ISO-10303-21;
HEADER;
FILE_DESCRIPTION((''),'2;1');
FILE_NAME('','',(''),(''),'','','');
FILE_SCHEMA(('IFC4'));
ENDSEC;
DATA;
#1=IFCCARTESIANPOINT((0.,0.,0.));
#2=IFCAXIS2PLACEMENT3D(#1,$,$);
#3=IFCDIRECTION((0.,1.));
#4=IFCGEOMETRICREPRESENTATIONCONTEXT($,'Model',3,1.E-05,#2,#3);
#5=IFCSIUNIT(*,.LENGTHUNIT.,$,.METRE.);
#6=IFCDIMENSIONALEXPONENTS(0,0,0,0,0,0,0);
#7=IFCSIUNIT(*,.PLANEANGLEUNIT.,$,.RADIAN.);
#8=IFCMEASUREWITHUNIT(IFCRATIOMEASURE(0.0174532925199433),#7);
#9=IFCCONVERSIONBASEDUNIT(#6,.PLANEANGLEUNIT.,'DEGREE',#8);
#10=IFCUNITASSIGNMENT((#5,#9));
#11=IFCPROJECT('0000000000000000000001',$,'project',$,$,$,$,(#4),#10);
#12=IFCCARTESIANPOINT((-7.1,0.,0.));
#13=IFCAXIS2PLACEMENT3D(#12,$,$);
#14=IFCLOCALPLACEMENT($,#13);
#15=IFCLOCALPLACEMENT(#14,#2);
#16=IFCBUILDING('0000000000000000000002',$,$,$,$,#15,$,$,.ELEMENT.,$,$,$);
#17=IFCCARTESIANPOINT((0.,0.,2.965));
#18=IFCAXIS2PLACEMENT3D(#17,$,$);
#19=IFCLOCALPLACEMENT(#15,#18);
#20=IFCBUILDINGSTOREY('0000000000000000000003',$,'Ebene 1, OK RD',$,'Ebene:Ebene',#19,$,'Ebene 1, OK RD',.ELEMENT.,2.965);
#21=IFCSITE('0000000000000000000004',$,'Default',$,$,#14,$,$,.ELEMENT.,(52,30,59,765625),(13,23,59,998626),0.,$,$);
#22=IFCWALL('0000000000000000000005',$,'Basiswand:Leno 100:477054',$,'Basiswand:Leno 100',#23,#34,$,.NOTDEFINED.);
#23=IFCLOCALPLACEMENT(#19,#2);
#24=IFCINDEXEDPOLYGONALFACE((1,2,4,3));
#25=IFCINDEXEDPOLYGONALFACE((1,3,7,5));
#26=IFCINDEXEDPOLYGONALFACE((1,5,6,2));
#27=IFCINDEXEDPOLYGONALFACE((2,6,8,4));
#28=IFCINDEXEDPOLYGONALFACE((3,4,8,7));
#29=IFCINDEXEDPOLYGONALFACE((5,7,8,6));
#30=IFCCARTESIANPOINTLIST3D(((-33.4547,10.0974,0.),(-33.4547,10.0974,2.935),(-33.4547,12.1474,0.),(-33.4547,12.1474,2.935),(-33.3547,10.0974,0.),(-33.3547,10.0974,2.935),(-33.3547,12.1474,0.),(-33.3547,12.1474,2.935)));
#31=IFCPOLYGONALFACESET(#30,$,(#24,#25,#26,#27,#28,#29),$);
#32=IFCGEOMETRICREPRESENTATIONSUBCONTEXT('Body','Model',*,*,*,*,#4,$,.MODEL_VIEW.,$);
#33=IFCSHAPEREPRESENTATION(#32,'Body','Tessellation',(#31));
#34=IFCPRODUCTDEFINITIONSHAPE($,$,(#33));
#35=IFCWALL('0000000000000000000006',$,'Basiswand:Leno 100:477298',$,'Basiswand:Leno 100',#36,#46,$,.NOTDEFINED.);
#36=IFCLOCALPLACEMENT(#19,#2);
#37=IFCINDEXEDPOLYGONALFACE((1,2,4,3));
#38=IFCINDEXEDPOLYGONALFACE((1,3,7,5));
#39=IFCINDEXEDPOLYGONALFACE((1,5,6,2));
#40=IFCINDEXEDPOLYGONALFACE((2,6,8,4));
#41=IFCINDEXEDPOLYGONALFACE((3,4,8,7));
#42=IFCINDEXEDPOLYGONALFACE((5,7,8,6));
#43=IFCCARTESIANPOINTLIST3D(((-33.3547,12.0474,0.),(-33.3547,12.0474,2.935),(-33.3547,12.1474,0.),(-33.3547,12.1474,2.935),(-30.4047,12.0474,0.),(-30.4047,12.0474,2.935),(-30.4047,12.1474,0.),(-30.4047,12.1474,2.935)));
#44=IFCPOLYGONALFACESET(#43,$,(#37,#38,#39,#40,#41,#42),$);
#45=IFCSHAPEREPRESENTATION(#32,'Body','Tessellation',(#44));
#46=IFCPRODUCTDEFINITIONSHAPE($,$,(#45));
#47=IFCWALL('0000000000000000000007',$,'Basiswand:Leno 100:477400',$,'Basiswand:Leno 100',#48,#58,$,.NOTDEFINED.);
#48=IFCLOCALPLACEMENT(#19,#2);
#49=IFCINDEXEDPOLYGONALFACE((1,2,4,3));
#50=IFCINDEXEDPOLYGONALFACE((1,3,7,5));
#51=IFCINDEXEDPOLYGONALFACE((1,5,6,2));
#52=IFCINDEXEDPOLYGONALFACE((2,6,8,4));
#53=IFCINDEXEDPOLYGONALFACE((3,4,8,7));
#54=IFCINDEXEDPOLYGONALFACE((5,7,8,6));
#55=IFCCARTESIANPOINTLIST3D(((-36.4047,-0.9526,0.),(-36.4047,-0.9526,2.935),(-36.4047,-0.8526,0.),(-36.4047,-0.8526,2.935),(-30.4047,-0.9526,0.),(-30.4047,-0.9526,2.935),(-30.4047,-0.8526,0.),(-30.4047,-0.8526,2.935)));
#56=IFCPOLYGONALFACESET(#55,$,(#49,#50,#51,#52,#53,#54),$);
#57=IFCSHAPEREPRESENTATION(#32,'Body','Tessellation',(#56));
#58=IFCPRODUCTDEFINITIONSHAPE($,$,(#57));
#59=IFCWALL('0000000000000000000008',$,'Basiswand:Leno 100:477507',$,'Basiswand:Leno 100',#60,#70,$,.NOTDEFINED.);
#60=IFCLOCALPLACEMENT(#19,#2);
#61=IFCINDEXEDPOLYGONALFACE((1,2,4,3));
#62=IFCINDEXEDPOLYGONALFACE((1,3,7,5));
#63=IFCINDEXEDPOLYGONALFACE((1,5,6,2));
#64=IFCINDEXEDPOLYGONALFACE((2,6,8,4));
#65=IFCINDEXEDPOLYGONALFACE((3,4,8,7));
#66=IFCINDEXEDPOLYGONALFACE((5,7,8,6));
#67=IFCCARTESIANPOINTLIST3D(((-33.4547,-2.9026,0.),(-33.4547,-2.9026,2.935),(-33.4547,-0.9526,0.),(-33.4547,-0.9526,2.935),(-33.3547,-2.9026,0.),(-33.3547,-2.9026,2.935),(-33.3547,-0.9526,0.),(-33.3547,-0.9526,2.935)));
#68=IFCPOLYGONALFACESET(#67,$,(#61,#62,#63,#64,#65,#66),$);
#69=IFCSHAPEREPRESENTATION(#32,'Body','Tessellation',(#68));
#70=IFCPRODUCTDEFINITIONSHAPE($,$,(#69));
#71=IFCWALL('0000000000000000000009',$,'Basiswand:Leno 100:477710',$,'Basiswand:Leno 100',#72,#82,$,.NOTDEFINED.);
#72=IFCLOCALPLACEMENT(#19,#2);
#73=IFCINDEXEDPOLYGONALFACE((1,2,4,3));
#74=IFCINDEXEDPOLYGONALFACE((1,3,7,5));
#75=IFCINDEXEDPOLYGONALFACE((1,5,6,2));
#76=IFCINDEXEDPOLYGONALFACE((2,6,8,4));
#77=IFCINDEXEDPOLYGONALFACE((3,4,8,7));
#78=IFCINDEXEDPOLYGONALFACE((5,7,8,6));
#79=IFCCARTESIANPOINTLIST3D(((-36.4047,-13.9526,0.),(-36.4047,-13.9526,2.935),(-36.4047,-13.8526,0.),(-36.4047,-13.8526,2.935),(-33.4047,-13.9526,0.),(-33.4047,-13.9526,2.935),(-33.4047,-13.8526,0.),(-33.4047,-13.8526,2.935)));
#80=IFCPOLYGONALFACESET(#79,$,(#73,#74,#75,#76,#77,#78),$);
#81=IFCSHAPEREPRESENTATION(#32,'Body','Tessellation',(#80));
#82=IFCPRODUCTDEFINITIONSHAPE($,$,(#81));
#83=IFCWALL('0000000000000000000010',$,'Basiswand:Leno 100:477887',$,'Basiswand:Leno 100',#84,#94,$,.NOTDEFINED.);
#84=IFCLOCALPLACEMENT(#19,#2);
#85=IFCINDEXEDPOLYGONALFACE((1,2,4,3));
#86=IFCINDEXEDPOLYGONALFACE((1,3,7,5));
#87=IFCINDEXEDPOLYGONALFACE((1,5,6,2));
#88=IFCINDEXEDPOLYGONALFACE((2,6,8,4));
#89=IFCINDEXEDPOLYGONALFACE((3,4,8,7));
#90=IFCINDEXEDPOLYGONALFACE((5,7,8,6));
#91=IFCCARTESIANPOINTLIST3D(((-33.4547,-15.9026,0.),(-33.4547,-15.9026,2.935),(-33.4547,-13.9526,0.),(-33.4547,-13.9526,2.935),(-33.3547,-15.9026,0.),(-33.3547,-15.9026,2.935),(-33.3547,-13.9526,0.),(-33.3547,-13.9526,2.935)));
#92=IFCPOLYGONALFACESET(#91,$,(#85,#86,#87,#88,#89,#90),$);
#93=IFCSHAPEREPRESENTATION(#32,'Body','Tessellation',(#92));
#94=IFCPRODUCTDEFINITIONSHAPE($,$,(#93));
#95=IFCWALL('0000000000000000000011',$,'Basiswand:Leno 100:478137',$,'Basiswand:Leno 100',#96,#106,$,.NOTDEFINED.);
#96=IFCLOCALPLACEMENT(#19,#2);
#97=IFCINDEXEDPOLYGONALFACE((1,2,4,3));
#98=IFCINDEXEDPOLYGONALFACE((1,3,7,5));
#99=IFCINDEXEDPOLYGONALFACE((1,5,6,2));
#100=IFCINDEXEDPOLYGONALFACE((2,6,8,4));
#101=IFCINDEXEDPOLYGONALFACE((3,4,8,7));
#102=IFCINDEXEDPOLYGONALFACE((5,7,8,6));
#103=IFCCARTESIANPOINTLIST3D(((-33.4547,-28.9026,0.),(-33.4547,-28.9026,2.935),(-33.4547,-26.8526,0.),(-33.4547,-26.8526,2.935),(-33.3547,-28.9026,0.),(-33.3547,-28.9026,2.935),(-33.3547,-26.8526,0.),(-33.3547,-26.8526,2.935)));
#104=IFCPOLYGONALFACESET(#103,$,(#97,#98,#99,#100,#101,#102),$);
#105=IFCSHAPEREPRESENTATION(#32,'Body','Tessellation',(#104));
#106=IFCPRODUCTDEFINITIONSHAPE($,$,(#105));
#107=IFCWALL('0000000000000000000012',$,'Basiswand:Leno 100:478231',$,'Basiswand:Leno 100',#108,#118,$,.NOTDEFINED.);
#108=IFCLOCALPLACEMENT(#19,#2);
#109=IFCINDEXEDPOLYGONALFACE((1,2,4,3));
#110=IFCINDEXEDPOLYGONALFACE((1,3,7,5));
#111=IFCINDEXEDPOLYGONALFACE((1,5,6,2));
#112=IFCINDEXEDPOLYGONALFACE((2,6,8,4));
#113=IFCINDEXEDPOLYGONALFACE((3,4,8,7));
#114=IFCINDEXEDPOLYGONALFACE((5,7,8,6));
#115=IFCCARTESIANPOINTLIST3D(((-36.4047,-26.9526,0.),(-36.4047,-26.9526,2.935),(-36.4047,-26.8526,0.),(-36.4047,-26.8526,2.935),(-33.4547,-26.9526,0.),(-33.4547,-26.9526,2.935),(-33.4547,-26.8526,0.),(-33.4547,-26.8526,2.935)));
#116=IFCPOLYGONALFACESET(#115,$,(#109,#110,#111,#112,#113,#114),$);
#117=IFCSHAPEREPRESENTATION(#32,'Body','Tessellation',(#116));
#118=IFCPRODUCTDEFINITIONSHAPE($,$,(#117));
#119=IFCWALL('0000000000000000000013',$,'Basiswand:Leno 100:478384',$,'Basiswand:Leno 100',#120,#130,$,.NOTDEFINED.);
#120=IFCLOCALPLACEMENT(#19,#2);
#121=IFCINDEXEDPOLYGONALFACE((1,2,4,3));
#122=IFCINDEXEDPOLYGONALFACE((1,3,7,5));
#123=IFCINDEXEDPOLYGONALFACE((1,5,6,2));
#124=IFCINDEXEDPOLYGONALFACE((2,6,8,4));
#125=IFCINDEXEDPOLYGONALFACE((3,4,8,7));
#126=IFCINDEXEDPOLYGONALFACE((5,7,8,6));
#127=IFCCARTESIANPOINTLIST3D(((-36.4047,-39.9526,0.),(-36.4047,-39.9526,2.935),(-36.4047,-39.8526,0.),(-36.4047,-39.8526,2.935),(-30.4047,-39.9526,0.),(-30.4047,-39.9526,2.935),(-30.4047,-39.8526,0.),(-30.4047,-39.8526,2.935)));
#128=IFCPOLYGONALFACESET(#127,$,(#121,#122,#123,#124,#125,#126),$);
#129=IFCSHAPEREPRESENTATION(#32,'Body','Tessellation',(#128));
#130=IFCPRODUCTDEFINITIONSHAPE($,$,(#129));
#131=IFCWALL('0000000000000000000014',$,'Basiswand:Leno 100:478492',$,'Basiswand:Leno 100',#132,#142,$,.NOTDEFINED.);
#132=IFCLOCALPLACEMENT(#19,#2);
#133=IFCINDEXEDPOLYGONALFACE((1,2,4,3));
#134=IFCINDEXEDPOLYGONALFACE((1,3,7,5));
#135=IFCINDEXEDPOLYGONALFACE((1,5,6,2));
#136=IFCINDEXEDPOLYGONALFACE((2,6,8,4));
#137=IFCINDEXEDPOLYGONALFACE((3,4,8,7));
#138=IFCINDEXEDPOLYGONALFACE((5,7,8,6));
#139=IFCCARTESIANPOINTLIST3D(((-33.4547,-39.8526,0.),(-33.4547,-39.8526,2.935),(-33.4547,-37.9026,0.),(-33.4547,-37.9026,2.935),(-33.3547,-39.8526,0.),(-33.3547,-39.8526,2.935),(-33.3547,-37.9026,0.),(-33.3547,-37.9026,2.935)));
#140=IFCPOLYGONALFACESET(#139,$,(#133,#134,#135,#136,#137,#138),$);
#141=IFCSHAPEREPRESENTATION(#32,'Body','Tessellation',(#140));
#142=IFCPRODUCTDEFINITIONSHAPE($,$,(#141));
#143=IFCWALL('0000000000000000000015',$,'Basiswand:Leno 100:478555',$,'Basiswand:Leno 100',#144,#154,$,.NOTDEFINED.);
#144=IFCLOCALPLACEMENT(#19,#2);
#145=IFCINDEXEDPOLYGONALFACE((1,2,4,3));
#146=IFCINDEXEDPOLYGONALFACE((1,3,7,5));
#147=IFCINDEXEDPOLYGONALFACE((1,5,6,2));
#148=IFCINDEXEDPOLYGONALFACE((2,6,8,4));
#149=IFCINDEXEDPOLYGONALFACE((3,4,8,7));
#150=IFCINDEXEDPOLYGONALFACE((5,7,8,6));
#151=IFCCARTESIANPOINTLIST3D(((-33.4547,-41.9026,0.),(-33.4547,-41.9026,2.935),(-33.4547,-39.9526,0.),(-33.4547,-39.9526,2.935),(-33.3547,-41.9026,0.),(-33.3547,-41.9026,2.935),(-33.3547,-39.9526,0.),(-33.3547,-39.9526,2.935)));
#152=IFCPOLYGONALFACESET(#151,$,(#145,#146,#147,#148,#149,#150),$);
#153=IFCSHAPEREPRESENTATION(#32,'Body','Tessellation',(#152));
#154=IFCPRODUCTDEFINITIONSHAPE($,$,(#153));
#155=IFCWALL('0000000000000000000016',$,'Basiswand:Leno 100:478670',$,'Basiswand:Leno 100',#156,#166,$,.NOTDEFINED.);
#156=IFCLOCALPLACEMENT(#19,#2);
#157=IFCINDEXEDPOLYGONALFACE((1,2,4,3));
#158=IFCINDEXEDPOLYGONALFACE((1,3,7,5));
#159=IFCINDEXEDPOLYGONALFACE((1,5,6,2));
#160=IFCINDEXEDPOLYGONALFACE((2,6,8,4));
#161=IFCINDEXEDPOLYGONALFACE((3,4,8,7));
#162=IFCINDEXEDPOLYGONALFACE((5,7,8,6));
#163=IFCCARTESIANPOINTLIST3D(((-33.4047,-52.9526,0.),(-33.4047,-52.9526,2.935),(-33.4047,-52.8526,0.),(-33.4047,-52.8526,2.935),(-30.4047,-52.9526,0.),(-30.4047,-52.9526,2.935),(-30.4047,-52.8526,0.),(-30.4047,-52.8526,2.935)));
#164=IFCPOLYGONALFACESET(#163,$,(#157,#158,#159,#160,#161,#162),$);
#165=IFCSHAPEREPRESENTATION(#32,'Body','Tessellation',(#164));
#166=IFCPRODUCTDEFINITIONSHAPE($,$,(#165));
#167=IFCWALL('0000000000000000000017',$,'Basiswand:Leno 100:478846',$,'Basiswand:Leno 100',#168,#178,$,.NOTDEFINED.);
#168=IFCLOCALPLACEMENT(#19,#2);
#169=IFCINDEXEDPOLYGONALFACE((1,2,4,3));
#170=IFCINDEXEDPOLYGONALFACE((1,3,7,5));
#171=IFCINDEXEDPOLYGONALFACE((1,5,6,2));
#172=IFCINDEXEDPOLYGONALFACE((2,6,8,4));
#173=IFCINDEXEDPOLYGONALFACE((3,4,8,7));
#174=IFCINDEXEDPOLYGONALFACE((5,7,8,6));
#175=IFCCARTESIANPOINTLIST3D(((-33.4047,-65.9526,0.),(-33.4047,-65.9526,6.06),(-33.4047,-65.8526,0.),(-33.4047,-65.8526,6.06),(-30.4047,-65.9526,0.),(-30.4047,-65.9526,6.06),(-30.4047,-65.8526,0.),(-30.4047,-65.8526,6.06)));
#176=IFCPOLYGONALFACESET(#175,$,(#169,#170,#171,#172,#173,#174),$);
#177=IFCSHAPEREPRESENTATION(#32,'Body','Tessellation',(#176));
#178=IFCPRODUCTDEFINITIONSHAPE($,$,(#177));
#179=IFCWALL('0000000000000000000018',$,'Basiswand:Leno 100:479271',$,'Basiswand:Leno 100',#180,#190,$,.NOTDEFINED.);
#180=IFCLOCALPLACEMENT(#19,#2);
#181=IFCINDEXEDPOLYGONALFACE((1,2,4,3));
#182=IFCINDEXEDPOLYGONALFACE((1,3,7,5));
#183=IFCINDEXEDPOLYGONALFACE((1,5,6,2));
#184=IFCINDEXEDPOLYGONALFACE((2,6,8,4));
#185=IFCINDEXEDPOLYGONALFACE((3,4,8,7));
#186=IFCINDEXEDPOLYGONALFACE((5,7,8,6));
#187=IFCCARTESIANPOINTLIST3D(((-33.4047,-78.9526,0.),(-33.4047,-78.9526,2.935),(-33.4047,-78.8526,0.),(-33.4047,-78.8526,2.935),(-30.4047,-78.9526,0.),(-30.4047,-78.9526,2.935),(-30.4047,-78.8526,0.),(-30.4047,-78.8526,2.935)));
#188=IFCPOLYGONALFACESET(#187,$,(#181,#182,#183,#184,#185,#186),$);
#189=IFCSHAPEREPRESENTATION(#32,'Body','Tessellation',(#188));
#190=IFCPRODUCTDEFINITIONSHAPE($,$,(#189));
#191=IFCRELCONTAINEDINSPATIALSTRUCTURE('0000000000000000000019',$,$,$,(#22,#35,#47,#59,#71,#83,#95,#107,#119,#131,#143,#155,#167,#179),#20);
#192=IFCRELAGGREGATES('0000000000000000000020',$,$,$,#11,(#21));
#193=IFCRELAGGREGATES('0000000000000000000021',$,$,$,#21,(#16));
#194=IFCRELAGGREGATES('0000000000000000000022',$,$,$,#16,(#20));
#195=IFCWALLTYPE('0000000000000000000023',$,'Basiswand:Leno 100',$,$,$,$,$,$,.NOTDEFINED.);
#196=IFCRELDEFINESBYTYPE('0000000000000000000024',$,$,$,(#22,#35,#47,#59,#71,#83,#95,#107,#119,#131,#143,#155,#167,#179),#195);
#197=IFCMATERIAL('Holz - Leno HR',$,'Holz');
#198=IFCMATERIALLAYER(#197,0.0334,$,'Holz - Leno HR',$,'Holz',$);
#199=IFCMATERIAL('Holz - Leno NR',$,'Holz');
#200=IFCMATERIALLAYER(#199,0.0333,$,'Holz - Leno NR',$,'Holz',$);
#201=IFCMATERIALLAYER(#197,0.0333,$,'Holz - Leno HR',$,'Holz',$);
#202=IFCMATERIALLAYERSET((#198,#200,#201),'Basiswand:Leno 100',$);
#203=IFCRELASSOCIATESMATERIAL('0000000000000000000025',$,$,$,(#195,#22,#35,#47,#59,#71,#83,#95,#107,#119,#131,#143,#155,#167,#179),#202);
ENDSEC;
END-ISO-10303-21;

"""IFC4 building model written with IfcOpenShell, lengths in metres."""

from ifc_helpers import new_model, entity, si_unit, converted_unit, direction, frame, origin, place, context, subcontext, project, spatial, indexed_curve, outline, extrude, material, layer, layer_set, type_object, element, save


model = new_model("IFC4")

# Units and contexts
model_context = context("Model", 3, precision=1e-05, world=origin(), true_north=direction((0.0, 1.0)))
body_context = subcontext(model_context, "Body", "Model", "MODEL_VIEW")
ifc_project = project(units=[si_unit("LENGTHUNIT", "METRE"), converted_unit("PLANEANGLEUNIT", "DEGREE", entity("IfcRatioMeasure", 0.0174532925199433), si_unit("PLANEANGLEUNIT", "RADIAN"), dimensions=[0, 0, 0, 0, 0, 0, 0])], contexts=[model_context])

# Site, building, storey
site_placement = place(None, frame((-7.1, 0.0, 0.0)))
site = spatial("IfcSite", under=ifc_project, at=site_placement, Name="Default", CompositionType="ELEMENT", RefLatitude=(52, 30, 59, 765625), RefLongitude=(13, 23, 59, 998626), RefElevation=0.0)
building_placement = place(site_placement, origin())
building = spatial("IfcBuilding", under=site, at=building_placement, CompositionType="ELEMENT")
storey_placement = place(building_placement, frame((0.0, 0.0, 2.965)))
storey = spatial("IfcBuildingStorey", under=building, at=storey_placement, Name="Ebene 1, OK RD", ObjectType="Ebene:Ebene", LongName="Ebene 1, OK RD", CompositionType="ELEMENT", Elevation=2.965)

# Walls
ifc_material_1 = material(Name="Holz - Leno HR", Category="Holz")
ifc_layer_1 = layer(ifc_material_1, 0.0334, Name="Holz - Leno HR", Category="Holz")
ifc_material_2 = material(Name="Holz - Leno NR", Category="Holz")
ifc_layer_2 = layer(ifc_material_2, 0.0333, Name="Holz - Leno NR", Category="Holz")
ifc_layer_3 = layer(ifc_material_1, 0.0333, Name="Holz - Leno HR", Category="Holz")
ifc_layer_set = layer_set([ifc_layer_1, ifc_layer_2, ifc_layer_3], Name="Basiswand:Leno 100")
wall_type = type_object("IfcWallType", Name="Basiswand:Leno 100", PredefinedType="NOTDEFINED", material=ifc_layer_set)
wall_1_placement = place(storey_placement, frame((-33.4047, 10.0974, 0.0), z_axis=(0.0, 0.0, 1.0), x_axis=(0.0, 1.0, 0.0)))
element("IfcWall", 1, at=wall_1_placement, inside=storey, type_object=wall_type, material=ifc_layer_set, Name="Basiswand:Leno 100:477054", ObjectType="Basiswand:Leno 100", PredefinedType="NOTDEFINED", context=body_context, shape_type="SweptSolid", body=[
    extrude(outline(indexed_curve([(2.05, 0.05), (0.0, 0.05), (0.0, -0.05), (2.05, -0.05), (2.05, 0.05)], self_intersect=False)), origin(), (0.0, 0.0, 1.0), 2.935),
])
wall_2_placement = place(storey_placement, frame((-30.4047, 12.0974, 0.0), z_axis=(0.0, 0.0, 1.0), x_axis=(-1.0, 0.0, 0.0)))
element("IfcWall", 2, at=wall_2_placement, inside=storey, type_object=wall_type, material=ifc_layer_set, Name="Basiswand:Leno 100:477298", ObjectType="Basiswand:Leno 100", PredefinedType="NOTDEFINED", context=body_context, shape_type="SweptSolid", body=[
    extrude(outline(indexed_curve([(2.95, 0.05), (0.0, 0.05), (0.0, -0.05), (2.95, -0.05), (2.95, 0.05)], self_intersect=False)), origin(), (0.0, 0.0, 1.0), 2.935),
])
wall_3_placement = place(storey_placement, frame((-30.4047, -0.9026, 0.0), z_axis=(0.0, 0.0, 1.0), x_axis=(-1.0, 0.0, 0.0)))
element("IfcWall", 3, at=wall_3_placement, inside=storey, type_object=wall_type, material=ifc_layer_set, Name="Basiswand:Leno 100:477400", ObjectType="Basiswand:Leno 100", PredefinedType="NOTDEFINED", context=body_context, shape_type="SweptSolid", body=[
    extrude(outline(indexed_curve([(6.0, 0.05), (0.0, 0.05), (0.0, -0.05), (6.0, -0.05), (6.0, 0.05)], self_intersect=False)), origin(), (0.0, 0.0, 1.0), 2.935),
])
wall_4_placement = place(storey_placement, frame((-33.4047, -2.9026, 0.0), z_axis=(0.0, 0.0, 1.0), x_axis=(0.0, 1.0, 0.0)))
element("IfcWall", 4, at=wall_4_placement, inside=storey, type_object=wall_type, material=ifc_layer_set, Name="Basiswand:Leno 100:477507", ObjectType="Basiswand:Leno 100", PredefinedType="NOTDEFINED", context=body_context, shape_type="SweptSolid", body=[
    extrude(outline(indexed_curve([(1.95, 0.05), (0.0, 0.05), (0.0, -0.05), (1.95, -0.05), (1.95, 0.05)], self_intersect=False)), origin(), (0.0, 0.0, 1.0), 2.935),
])
wall_5_placement = place(storey_placement, frame((-36.4047, -13.9026, 0.0)))
element("IfcWall", 5, at=wall_5_placement, inside=storey, type_object=wall_type, material=ifc_layer_set, Name="Basiswand:Leno 100:477710", ObjectType="Basiswand:Leno 100", PredefinedType="NOTDEFINED", context=body_context, shape_type="SweptSolid", body=[
    extrude(outline(indexed_curve([(3.0, 0.05), (0.0, 0.05), (0.0, -0.05), (3.0, -0.05), (3.0, 0.05)], self_intersect=False)), origin(), (0.0, 0.0, 1.0), 2.935),
])
wall_6_placement = place(storey_placement, frame((-33.4047, -15.9026, 0.0), z_axis=(0.0, 0.0, 1.0), x_axis=(0.0, 1.0, 0.0)))
element("IfcWall", 6, at=wall_6_placement, inside=storey, type_object=wall_type, material=ifc_layer_set, Name="Basiswand:Leno 100:477887", ObjectType="Basiswand:Leno 100", PredefinedType="NOTDEFINED", context=body_context, shape_type="SweptSolid", body=[
    extrude(outline(indexed_curve([(1.95, 0.05), (0.0, 0.05), (0.0, -0.05), (1.95, -0.05), (1.95, 0.05)], self_intersect=False)), origin(), (0.0, 0.0, 1.0), 2.935),
])
wall_7_placement = place(storey_placement, frame((-33.4047, -28.9026, 0.0), z_axis=(0.0, 0.0, 1.0), x_axis=(0.0, 1.0, 0.0)))
element("IfcWall", 7, at=wall_7_placement, inside=storey, type_object=wall_type, material=ifc_layer_set, Name="Basiswand:Leno 100:478137", ObjectType="Basiswand:Leno 100", PredefinedType="NOTDEFINED", context=body_context, shape_type="SweptSolid", body=[
    extrude(outline(indexed_curve([(2.05, 0.05), (0.0, 0.05), (0.0, -0.05), (2.05, -0.05), (2.05, 0.05)], self_intersect=False)), origin(), (0.0, 0.0, 1.0), 2.935),
])
wall_8_placement = place(storey_placement, frame((-36.4047, -26.9026, 0.0)))
element("IfcWall", 8, at=wall_8_placement, inside=storey, type_object=wall_type, material=ifc_layer_set, Name="Basiswand:Leno 100:478231", ObjectType="Basiswand:Leno 100", PredefinedType="NOTDEFINED", context=body_context, shape_type="SweptSolid", body=[
    extrude(outline(indexed_curve([(2.95, 0.05), (0.0, 0.05), (0.0, -0.05), (2.95, -0.05), (2.95, 0.05)], self_intersect=False)), origin(), (0.0, 0.0, 1.0), 2.935),
])
wall_9_placement = place(storey_placement, frame((-36.4047, -39.9026, 0.0)))
element("IfcWall", 9, at=wall_9_placement, inside=storey, type_object=wall_type, material=ifc_layer_set, Name="Basiswand:Leno 100:478384", ObjectType="Basiswand:Leno 100", PredefinedType="NOTDEFINED", context=body_context, shape_type="SweptSolid", body=[
    extrude(outline(indexed_curve([(6.0, 0.05), (0.0, 0.05), (0.0, -0.05), (6.0, -0.05), (6.0, 0.05)], self_intersect=False)), origin(), (0.0, 0.0, 1.0), 2.935),
])
wall_10_placement = place(storey_placement, frame((-33.4047, -37.9026, 0.0), z_axis=(0.0, 0.0, 1.0), x_axis=(0.0, -1.0, 0.0)))
element("IfcWall", 10, at=wall_10_placement, inside=storey, type_object=wall_type, material=ifc_layer_set, Name="Basiswand:Leno 100:478492", ObjectType="Basiswand:Leno 100", PredefinedType="NOTDEFINED", context=body_context, shape_type="SweptSolid", body=[
    extrude(outline(indexed_curve([(1.95, 0.05), (0.0, 0.05), (0.0, -0.05), (1.95, -0.05), (1.95, 0.05)], self_intersect=False)), origin(), (0.0, 0.0, 1.0), 2.935),
])
wall_11_placement = place(storey_placement, frame((-33.4047, -41.9026, 0.0), z_axis=(0.0, 0.0, 1.0), x_axis=(0.0, 1.0, 0.0)))
element("IfcWall", 11, at=wall_11_placement, inside=storey, type_object=wall_type, material=ifc_layer_set, Name="Basiswand:Leno 100:478555", ObjectType="Basiswand:Leno 100", PredefinedType="NOTDEFINED", context=body_context, shape_type="SweptSolid", body=[
    extrude(outline(indexed_curve([(1.95, 0.05), (0.0, 0.05), (0.0, -0.05), (1.95, -0.05), (1.95, 0.05)], self_intersect=False)), origin(), (0.0, 0.0, 1.0), 2.935),
])
wall_12_placement = place(storey_placement, frame((-30.4047, -52.9026, 0.0), z_axis=(0.0, 0.0, 1.0), x_axis=(-1.0, 0.0, 0.0)))
element("IfcWall", 12, at=wall_12_placement, inside=storey, type_object=wall_type, material=ifc_layer_set, Name="Basiswand:Leno 100:478670", ObjectType="Basiswand:Leno 100", PredefinedType="NOTDEFINED", context=body_context, shape_type="SweptSolid", body=[
    extrude(outline(indexed_curve([(3.0, 0.05), (0.0, 0.05), (0.0, -0.05), (3.0, -0.05), (3.0, 0.05)], self_intersect=False)), origin(), (0.0, 0.0, 1.0), 2.935),
])
wall_13_placement = place(storey_placement, frame((-30.4047, -65.9026, 0.0), z_axis=(0.0, 0.0, 1.0), x_axis=(-1.0, 0.0, 0.0)))
element("IfcWall", 13, at=wall_13_placement, inside=storey, type_object=wall_type, material=ifc_layer_set, Name="Basiswand:Leno 100:478846", ObjectType="Basiswand:Leno 100", PredefinedType="NOTDEFINED", context=body_context, shape_type="SweptSolid", body=[
    extrude(outline(indexed_curve([(3.0, 0.05), (0.0, 0.05), (0.0, -0.05), (3.0, -0.05), (3.0, 0.05)], self_intersect=False)), origin(), (0.0, 0.0, 1.0), 6.06),
])
wall_14_placement = place(storey_placement, frame((-30.4047, -78.9026, 0.0), z_axis=(0.0, 0.0, 1.0), x_axis=(-1.0, 0.0, 0.0)))
element("IfcWall", 14, at=wall_14_placement, inside=storey, type_object=wall_type, material=ifc_layer_set, Name="Basiswand:Leno 100:479271", ObjectType="Basiswand:Leno 100", PredefinedType="NOTDEFINED", context=body_context, shape_type="SweptSolid", body=[
    extrude(outline(indexed_curve([(3.0, 0.05), (0.0, 0.05), (0.0, -0.05), (3.0, -0.05), (3.0, 0.05)], self_intersect=False)), origin(), (0.0, 0.0, 1.0), 2.935),
])

save(model, "model.ifc")
